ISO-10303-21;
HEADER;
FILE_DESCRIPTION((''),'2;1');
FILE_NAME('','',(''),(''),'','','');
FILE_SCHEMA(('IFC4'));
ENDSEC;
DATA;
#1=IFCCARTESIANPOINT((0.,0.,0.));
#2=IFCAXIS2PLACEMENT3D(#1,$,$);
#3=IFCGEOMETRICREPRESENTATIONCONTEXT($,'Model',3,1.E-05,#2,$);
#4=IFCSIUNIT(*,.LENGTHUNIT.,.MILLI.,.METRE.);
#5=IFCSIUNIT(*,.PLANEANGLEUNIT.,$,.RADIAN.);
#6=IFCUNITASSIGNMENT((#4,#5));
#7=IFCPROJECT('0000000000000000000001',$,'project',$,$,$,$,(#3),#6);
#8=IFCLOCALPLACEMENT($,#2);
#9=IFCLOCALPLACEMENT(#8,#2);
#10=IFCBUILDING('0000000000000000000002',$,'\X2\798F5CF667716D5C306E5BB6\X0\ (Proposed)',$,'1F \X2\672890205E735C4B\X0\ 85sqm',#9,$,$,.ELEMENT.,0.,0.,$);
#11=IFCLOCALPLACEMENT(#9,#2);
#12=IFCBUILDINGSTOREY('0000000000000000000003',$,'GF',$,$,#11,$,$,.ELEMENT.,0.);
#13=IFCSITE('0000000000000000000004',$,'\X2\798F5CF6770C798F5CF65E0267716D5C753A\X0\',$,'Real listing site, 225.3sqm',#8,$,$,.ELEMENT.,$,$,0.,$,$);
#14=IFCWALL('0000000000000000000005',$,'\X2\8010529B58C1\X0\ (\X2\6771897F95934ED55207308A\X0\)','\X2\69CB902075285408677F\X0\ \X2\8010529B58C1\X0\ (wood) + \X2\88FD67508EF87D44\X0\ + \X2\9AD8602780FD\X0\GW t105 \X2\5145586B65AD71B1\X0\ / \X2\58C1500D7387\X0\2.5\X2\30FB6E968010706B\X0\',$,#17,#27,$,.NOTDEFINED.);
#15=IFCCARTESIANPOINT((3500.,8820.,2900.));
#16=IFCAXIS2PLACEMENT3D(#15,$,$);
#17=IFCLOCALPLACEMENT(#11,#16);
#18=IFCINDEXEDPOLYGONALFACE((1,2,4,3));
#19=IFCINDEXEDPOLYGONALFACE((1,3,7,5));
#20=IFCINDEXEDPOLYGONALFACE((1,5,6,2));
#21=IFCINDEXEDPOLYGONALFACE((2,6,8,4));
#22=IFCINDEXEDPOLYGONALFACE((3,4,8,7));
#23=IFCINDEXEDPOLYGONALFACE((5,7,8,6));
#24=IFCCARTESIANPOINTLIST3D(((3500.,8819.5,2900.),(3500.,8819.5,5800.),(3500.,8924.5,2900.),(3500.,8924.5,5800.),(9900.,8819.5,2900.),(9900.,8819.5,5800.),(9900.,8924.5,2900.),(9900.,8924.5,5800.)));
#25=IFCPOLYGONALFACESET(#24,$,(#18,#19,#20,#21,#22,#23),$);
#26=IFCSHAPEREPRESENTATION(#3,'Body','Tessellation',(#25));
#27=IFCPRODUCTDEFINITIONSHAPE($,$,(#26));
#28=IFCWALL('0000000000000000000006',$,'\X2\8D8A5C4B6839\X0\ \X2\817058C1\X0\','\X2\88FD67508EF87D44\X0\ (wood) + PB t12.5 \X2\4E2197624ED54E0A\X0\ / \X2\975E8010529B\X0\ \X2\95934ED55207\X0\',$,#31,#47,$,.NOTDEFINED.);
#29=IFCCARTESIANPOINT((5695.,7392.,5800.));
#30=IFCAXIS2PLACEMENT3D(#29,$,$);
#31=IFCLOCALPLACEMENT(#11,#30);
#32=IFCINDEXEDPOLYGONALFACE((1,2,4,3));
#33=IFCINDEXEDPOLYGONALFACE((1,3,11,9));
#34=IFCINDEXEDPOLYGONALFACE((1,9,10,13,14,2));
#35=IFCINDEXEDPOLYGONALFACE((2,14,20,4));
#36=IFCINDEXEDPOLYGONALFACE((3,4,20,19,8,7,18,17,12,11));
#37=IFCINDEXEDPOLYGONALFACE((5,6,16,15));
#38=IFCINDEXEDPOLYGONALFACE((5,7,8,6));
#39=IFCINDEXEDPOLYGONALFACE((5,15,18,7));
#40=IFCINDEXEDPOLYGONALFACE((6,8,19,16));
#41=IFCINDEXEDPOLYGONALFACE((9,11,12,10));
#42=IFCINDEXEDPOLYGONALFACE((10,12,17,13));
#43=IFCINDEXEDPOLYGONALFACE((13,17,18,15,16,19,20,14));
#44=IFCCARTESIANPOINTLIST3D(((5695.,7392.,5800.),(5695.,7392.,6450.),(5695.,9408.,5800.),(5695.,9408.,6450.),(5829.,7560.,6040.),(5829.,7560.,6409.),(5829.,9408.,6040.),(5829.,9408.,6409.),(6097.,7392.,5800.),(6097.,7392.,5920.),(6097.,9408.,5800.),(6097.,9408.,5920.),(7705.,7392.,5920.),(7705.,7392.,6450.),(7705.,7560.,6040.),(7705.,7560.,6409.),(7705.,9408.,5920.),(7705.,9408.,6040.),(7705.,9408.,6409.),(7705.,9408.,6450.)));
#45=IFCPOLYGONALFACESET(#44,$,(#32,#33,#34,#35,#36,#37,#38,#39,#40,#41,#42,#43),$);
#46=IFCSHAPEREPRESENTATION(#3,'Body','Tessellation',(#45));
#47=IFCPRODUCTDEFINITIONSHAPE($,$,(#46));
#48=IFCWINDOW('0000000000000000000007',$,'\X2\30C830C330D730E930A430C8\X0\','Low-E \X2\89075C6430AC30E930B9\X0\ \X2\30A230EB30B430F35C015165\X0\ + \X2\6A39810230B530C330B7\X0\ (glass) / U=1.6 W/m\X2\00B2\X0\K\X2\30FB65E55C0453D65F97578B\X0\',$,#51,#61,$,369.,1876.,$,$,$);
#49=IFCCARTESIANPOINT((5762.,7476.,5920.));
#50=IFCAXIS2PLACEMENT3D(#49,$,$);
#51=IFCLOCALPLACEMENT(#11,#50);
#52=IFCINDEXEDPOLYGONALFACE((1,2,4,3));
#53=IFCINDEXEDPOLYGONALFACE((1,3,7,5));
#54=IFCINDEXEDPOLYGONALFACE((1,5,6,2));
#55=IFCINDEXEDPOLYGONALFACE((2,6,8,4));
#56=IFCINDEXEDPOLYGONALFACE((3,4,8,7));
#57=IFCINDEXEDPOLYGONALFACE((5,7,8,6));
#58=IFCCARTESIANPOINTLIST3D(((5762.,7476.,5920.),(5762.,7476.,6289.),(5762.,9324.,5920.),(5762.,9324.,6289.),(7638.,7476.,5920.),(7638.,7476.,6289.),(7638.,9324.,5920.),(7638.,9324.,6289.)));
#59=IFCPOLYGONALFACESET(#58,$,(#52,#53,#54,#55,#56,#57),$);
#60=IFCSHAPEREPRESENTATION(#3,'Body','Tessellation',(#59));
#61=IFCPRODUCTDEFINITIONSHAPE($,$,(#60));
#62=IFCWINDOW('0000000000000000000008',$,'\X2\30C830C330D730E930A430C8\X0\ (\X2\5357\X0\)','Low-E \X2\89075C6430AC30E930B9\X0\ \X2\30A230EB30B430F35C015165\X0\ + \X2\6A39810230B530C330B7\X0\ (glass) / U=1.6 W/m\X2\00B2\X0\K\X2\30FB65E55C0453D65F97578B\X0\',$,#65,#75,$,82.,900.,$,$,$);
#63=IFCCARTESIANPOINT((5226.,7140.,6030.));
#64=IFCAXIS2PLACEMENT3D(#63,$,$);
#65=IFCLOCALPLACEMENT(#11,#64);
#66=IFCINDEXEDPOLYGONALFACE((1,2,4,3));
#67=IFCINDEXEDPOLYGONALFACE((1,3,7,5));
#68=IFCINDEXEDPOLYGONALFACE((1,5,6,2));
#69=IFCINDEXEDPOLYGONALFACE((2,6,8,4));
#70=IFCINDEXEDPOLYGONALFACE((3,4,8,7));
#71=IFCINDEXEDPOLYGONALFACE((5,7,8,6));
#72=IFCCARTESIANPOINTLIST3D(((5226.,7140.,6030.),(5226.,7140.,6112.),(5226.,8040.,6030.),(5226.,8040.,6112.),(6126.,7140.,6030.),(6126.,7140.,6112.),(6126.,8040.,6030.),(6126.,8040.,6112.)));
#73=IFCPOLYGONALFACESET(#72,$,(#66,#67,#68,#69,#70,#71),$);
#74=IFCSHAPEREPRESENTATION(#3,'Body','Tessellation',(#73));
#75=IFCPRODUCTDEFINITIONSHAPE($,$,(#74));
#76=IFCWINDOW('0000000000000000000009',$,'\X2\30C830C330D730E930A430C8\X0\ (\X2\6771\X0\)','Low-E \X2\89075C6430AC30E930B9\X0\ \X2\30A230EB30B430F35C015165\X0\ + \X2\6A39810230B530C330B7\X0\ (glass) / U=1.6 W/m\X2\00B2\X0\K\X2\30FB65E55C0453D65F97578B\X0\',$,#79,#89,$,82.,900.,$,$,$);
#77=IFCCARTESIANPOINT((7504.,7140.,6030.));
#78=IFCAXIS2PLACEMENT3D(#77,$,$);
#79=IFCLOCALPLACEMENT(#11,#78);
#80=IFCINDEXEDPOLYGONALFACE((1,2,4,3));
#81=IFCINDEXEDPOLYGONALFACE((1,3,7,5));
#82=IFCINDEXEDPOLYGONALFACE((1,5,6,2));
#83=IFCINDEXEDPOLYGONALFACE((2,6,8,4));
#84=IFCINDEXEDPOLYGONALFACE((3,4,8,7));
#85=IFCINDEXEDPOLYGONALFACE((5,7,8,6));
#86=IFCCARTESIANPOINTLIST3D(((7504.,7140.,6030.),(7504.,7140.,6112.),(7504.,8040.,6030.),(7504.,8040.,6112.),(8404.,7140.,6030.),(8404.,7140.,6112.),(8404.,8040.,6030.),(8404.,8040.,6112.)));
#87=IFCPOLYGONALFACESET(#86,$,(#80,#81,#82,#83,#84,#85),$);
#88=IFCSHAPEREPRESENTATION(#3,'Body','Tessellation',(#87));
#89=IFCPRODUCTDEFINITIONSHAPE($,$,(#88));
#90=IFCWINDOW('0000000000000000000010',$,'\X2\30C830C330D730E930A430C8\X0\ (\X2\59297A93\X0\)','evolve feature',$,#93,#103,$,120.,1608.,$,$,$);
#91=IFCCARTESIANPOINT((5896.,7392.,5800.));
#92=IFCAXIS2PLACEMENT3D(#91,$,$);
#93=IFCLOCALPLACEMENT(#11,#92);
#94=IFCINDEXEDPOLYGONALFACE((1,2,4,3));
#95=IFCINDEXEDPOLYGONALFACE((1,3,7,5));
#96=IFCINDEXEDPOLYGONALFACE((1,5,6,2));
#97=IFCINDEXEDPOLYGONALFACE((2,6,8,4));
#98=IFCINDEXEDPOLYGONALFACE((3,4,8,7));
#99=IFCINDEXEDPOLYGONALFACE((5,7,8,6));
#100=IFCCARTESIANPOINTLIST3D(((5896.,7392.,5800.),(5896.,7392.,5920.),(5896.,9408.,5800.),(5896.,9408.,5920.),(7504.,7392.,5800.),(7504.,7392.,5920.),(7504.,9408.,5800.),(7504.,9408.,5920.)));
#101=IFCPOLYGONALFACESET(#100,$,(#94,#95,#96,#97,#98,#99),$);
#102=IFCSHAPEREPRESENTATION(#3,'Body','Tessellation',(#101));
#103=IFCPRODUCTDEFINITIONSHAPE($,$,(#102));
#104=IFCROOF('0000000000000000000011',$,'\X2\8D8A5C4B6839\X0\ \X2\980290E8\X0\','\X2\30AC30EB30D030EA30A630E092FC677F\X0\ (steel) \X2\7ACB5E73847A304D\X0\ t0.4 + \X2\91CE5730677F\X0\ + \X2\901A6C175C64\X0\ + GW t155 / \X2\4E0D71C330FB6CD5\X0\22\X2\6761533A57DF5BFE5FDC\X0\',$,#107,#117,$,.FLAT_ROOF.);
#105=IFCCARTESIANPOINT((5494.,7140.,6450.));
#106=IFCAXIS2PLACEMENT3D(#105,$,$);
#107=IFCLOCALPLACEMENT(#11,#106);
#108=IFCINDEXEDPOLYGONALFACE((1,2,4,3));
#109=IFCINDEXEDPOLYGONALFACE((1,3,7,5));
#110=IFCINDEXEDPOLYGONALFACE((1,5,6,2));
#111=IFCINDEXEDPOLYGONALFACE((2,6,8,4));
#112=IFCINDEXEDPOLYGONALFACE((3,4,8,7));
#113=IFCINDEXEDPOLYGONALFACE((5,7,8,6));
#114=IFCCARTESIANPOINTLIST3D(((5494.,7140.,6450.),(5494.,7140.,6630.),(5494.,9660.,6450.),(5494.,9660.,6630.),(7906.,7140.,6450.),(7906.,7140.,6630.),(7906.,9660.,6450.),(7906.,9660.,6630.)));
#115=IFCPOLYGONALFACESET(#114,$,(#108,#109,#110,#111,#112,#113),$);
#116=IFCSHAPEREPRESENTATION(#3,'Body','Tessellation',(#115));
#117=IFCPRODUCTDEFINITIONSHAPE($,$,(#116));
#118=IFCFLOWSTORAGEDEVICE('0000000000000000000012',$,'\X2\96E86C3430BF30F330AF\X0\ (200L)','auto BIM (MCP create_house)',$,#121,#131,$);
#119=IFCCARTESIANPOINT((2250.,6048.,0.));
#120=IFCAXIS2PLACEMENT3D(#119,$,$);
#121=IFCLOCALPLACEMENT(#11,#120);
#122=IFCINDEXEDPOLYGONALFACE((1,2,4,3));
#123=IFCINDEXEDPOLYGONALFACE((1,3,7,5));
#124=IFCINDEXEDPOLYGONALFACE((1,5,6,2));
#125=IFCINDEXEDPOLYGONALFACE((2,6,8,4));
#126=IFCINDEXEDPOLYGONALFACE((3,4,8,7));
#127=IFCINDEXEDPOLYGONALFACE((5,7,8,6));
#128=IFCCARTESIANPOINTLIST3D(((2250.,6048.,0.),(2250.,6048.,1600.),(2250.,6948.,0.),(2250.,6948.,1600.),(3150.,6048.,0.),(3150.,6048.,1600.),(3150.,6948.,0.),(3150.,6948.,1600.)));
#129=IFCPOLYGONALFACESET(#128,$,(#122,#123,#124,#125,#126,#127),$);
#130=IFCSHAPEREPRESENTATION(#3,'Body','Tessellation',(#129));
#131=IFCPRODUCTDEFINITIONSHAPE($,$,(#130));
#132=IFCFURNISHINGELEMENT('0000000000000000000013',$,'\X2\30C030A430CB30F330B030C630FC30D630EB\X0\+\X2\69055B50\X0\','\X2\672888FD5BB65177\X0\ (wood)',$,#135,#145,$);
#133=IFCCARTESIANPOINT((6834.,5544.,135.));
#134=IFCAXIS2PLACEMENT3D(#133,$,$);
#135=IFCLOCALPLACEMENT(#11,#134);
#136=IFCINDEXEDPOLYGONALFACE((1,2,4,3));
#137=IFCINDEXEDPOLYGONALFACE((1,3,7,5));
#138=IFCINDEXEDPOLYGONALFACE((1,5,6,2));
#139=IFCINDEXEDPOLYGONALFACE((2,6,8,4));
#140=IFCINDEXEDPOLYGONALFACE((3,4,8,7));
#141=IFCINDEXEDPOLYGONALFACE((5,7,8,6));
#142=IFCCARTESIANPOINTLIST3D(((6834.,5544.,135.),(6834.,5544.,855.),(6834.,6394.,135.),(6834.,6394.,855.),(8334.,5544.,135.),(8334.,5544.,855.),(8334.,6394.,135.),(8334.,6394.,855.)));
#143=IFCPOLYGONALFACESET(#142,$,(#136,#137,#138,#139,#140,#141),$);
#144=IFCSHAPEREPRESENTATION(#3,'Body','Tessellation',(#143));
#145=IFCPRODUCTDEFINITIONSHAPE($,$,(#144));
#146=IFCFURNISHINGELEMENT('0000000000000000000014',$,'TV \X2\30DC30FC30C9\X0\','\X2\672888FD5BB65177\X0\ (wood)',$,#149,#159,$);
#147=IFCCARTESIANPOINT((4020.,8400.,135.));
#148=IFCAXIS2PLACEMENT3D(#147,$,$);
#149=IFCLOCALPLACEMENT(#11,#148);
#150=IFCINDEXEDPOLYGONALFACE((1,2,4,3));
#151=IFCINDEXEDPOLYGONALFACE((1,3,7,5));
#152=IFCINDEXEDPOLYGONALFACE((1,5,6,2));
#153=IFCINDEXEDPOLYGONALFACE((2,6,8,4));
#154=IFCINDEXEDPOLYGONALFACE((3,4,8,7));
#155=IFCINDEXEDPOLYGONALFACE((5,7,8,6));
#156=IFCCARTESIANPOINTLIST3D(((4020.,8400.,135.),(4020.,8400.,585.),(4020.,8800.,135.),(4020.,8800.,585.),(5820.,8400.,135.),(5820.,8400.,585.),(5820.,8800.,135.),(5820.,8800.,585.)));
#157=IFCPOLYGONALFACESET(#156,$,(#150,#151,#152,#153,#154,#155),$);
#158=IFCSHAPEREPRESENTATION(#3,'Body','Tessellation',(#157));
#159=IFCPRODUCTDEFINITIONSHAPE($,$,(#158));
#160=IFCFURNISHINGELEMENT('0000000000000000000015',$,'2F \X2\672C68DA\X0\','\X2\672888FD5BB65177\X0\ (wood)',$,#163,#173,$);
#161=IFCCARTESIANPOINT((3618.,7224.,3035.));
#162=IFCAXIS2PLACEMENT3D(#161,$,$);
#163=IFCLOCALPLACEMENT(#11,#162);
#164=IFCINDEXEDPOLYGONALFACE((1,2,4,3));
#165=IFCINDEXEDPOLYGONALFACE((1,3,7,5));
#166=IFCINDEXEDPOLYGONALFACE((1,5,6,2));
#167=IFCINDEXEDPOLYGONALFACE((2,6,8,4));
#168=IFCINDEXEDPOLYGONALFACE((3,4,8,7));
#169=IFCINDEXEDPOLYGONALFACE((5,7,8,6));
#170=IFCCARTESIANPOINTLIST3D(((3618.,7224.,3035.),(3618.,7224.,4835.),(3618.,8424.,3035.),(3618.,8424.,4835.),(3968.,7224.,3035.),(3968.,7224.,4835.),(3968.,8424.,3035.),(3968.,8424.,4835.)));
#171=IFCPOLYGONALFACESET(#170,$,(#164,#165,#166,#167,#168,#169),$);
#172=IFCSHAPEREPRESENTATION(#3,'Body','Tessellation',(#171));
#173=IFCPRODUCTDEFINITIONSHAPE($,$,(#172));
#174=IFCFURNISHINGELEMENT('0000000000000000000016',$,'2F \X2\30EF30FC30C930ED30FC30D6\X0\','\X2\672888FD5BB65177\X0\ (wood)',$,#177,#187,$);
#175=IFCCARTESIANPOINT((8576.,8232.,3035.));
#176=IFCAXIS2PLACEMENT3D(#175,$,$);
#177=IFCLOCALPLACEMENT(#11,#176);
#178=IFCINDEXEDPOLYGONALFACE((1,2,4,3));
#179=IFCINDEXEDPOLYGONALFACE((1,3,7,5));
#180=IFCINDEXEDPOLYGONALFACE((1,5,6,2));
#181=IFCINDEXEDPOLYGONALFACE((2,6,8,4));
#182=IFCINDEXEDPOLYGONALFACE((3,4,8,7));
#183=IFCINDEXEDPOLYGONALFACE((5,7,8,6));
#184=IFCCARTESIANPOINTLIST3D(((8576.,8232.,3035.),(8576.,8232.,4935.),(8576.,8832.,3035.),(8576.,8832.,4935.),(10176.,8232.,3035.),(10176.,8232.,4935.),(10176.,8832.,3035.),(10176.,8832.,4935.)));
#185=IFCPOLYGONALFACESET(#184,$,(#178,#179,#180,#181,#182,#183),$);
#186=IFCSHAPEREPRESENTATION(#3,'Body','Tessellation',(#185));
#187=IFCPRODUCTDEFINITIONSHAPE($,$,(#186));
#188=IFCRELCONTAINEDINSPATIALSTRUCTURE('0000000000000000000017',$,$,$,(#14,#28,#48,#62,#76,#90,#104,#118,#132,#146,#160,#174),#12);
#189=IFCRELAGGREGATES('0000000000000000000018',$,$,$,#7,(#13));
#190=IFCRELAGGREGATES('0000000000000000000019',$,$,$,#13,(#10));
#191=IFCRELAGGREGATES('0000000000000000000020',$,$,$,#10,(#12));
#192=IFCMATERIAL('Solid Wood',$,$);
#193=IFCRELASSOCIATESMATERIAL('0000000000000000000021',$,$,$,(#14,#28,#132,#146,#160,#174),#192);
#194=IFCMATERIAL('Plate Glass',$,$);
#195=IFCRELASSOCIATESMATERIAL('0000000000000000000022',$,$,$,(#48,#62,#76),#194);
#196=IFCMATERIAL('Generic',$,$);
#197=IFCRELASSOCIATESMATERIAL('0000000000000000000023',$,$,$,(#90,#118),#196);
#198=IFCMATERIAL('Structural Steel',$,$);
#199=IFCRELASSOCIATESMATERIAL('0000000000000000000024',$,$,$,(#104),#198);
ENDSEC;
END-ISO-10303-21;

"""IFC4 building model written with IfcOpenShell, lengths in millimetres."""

from ifc_helpers import new_model, si_unit, frame, frame_2d, origin, place, context, project, spatial, rectangle, extrude, material, element, fill, save


model = new_model("IFC4")

# Units and contexts
model_context = context("Model", 3, precision=1e-05, world=origin())
ifc_project = project(units=[si_unit("LENGTHUNIT", "METRE", prefix="MILLI"), si_unit("PLANEANGLEUNIT", "RADIAN")], contexts=[model_context])

# Site, building, storey
site_placement = place(None, origin())
site = spatial("IfcSite", under=ifc_project, at=site_placement, Name="福島県福島市東浜町", ObjectType="Real listing site, 225.3sqm", CompositionType="ELEMENT", RefElevation=0.0)
building_placement = place(site_placement, origin())
building = spatial("IfcBuilding", under=site, at=building_placement, Name="福島東浜の家 (Proposed)", ObjectType="1F 木造平屋 85sqm", CompositionType="ELEMENT", ElevationOfRefHeight=0.0, ElevationOfTerrain=0.0)
storey_placement = place(building_placement, origin())
storey = spatial("IfcBuildingStorey", under=building, at=storey_placement, Name="GF", CompositionType="ELEMENT", Elevation=0.0)

# Wall
ifc_material_1 = material(Name="Solid Wood")
wall_1_placement = place(storey_placement, frame((3500.0, 8820.0, 2900.0)))
element("IfcWall", 1, at=wall_1_placement, inside=storey, material=ifc_material_1, Name="耐力壁 (東西間仕切り)", Description="構造用合板 耐力壁 (wood) + 製材軸組 + 高性能GW t105 充填断熱 / 壁倍率2.5・準耐火", PredefinedType="NOTDEFINED", context=model_context, shape_type="SweptSolid", body=[
    extrude(rectangle(XDim=6400.0, YDim=105.0, at=frame_2d((3200.0, 52.0))), frame((3500.0, 8820.0, 2900.0)), (0.0, 0.0, 1.0), 2900.0),
])

# Wall, openings, windows
wall_2_placement = place(storey_placement, frame((5695.0, 7392.0, 5800.0)))
wall_2 = element("IfcWall", 2, at=wall_2_placement, inside=storey, material=ifc_material_1, Name="越屋根 腰壁", Description="製材軸組 (wood) + PB t12.5 両面仕上 / 非耐力 間仕切", PredefinedType="NOTDEFINED", context=model_context, shape_type="SweptSolid", body=[
    extrude(rectangle(XDim=2010.0, YDim=2016.0, at=frame_2d((1005.0, 1008.0))), frame((5695.0, 7392.0, 5800.0)), (0.0, 0.0, 1.0), 650.0),
])
opening_1_placement = place(storey_placement, frame((5762.0, 7476.0, 5920.0)))
opening_1 = element("IfcOpeningElement", 3, at=opening_1_placement, cuts=wall_2, PredefinedType="NOTDEFINED", context=model_context, shape_type="SweptSolid", body=[
    extrude(rectangle(XDim=1876.0, YDim=1848.0, at=frame_2d((938.0, 924.0))), frame((5762.0, 7476.0, 5920.0)), (0.0, 0.0, 1.0), 369.0),
])
opening_2_placement = place(storey_placement, frame((5226.0, 7140.0, 6030.0)))
opening_2 = element("IfcOpeningElement", 4, at=opening_2_placement, cuts=wall_2, PredefinedType="NOTDEFINED", context=model_context, shape_type="SweptSolid", body=[
    extrude(rectangle(XDim=900.0, YDim=900.0, at=frame_2d((450.0, 450.0))), frame((5226.0, 7140.0, 6030.0)), (0.0, 0.0, 1.0), 82.0),
])
opening_3_placement = place(storey_placement, frame((7504.0, 7140.0, 6030.0)))
opening_3 = element("IfcOpeningElement", 5, at=opening_3_placement, cuts=wall_2, PredefinedType="NOTDEFINED", context=model_context, shape_type="SweptSolid", body=[
    extrude(rectangle(XDim=900.0, YDim=900.0, at=frame_2d((450.0, 450.0))), frame((7504.0, 7140.0, 6030.0)), (0.0, 0.0, 1.0), 82.0),
])
opening_4_placement = place(storey_placement, frame((5896.0, 7392.0, 5800.0)))
opening_4 = element("IfcOpeningElement", 6, at=opening_4_placement, cuts=wall_2, PredefinedType="NOTDEFINED", context=model_context, shape_type="SweptSolid", body=[
    extrude(rectangle(XDim=1608.0, YDim=2016.0, at=frame_2d((804.0, 1008.0))), frame((5896.0, 7392.0, 5800.0)), (0.0, 0.0, 1.0), 120.0),
])
ifc_material_2 = material(Name="Plate Glass")
window_1_placement = place(storey_placement, frame((5762.0, 7476.0, 5920.0)))
window_1 = element("IfcWindow", 7, at=window_1_placement, inside=storey, material=ifc_material_2, Name="トップライト", Description="Low-E 複層ガラス アルゴン封入 + 樹脂サッシ (glass) / U=1.6 W/m²K・日射取得型", OverallHeight=369.0, OverallWidth=1876.0, context=model_context, shape_type="SweptSolid", body=[
    extrude(rectangle(XDim=1876.0, YDim=1848.0, at=frame_2d((938.0, 924.0))), frame((5762.0, 7476.0, 5920.0)), (0.0, 0.0, 1.0), 369.0),
])
fill(opening_1, window_1)
window_2_placement = place(storey_placement, frame((5226.0, 7140.0, 6030.0)))
window_2 = element("IfcWindow", 8, at=window_2_placement, inside=storey, material=ifc_material_2, Name="トップライト (南)", Description="Low-E 複層ガラス アルゴン封入 + 樹脂サッシ (glass) / U=1.6 W/m²K・日射取得型", OverallHeight=82.0, OverallWidth=900.0, context=model_context, shape_type="SweptSolid", body=[
    extrude(rectangle(XDim=900.0, YDim=900.0, at=frame_2d((450.0, 450.0))), frame((5226.0, 7140.0, 6030.0)), (0.0, 0.0, 1.0), 82.0),
])
fill(opening_2, window_2)
window_3_placement = place(storey_placement, frame((7504.0, 7140.0, 6030.0)))
window_3 = element("IfcWindow", 9, at=window_3_placement, inside=storey, material=ifc_material_2, Name="トップライト (東)", Description="Low-E 複層ガラス アルゴン封入 + 樹脂サッシ (glass) / U=1.6 W/m²K・日射取得型", OverallHeight=82.0, OverallWidth=900.0, context=model_context, shape_type="SweptSolid", body=[
    extrude(rectangle(XDim=900.0, YDim=900.0, at=frame_2d((450.0, 450.0))), frame((7504.0, 7140.0, 6030.0)), (0.0, 0.0, 1.0), 82.0),
])
fill(opening_3, window_3)
ifc_material_3 = material(Name="Generic")
window_4_placement = place(storey_placement, frame((5896.0, 7392.0, 5800.0)))
window_4 = element("IfcWindow", 10, at=window_4_placement, inside=storey, material=ifc_material_3, Name="トップライト (天窓)", Description="evolve feature", OverallHeight=120.0, OverallWidth=1608.0, context=model_context, shape_type="SweptSolid", body=[
    extrude(rectangle(XDim=1608.0, YDim=2016.0, at=frame_2d((804.0, 1008.0))), frame((5896.0, 7392.0, 5800.0)), (0.0, 0.0, 1.0), 120.0),
])
fill(opening_4, window_4)

# Roof
ifc_material_4 = material(Name="Structural Steel")
roof_placement = place(storey_placement, frame((5494.0, 7140.0, 6450.0)))
element("IfcRoof", 11, at=roof_placement, inside=storey, material=ifc_material_4, Name="越屋根 頂部", Description="ガルバリウム鋼板 (steel) 立平葺き t0.4 + 野地板 + 通気層 + GW t155 / 不燃・法22条区域対応", PredefinedType="FLAT_ROOF", context=model_context, shape_type="SweptSolid", body=[
    extrude(rectangle(XDim=2412.0, YDim=2520.0, at=frame_2d((1206.0, 1260.0))), frame((5494.0, 7140.0, 6450.0)), (0.0, 0.0, 1.0), 180.0),
])

# Flow storage device
flow_storage_device_placement = place(storey_placement, frame((2250.0, 6048.0, 0.0)))
element("IfcFlowStorageDevice", 12, at=flow_storage_device_placement, inside=storey, material=ifc_material_3, Name="雨水タンク (200L)", Description="auto BIM (MCP create_house)", context=model_context, shape_type="SweptSolid", body=[
    extrude(rectangle(XDim=900.0, YDim=900.0, at=frame_2d((450.0, 450.0))), frame((2250.0, 6048.0, 0.0)), (0.0, 0.0, 1.0), 1600.0),
])

# Furnishing elements
furnishing_1_placement = place(storey_placement, frame((6834.0, 5544.0, 135.0)))
element("IfcFurnishingElement", 13, at=furnishing_1_placement, inside=storey, material=ifc_material_1, Name="ダイニングテーブル+椅子", Description="木製家具 (wood)", context=model_context, shape_type="SweptSolid", body=[
    extrude(rectangle(XDim=1500.0, YDim=850.0, at=frame_2d((750.0, 425.0))), frame((6834.0, 5544.0, 135.0)), (0.0, 0.0, 1.0), 720.0),
])
furnishing_2_placement = place(storey_placement, frame((4020.0, 8400.0, 135.0)))
element("IfcFurnishingElement", 14, at=furnishing_2_placement, inside=storey, material=ifc_material_1, Name="TV ボード", Description="木製家具 (wood)", context=model_context, shape_type="SweptSolid", body=[
    extrude(rectangle(XDim=1800.0, YDim=400.0, at=frame_2d((900.0, 200.0))), frame((4020.0, 8400.0, 135.0)), (0.0, 0.0, 1.0), 450.0),
])
furnishing_3_placement = place(storey_placement, frame((3618.0, 7224.0, 3035.0)))
element("IfcFurnishingElement", 15, at=furnishing_3_placement, inside=storey, material=ifc_material_1, Name="2F 本棚", Description="木製家具 (wood)", context=model_context, shape_type="SweptSolid", body=[
    extrude(rectangle(XDim=350.0, YDim=1200.0, at=frame_2d((175.0, 600.0))), frame((3618.0, 7224.0, 3035.0)), (0.0, 0.0, 1.0), 1800.0),
])
furnishing_4_placement = place(storey_placement, frame((8576.0, 8232.0, 3035.0)))
element("IfcFurnishingElement", 16, at=furnishing_4_placement, inside=storey, material=ifc_material_1, Name="2F ワードローブ", Description="木製家具 (wood)", context=model_context, shape_type="SweptSolid", body=[
    extrude(rectangle(XDim=1600.0, YDim=600.0, at=frame_2d((800.0, 300.0))), frame((8576.0, 8232.0, 3035.0)), (0.0, 0.0, 1.0), 1900.0),
])

save(model, "model.ifc")
